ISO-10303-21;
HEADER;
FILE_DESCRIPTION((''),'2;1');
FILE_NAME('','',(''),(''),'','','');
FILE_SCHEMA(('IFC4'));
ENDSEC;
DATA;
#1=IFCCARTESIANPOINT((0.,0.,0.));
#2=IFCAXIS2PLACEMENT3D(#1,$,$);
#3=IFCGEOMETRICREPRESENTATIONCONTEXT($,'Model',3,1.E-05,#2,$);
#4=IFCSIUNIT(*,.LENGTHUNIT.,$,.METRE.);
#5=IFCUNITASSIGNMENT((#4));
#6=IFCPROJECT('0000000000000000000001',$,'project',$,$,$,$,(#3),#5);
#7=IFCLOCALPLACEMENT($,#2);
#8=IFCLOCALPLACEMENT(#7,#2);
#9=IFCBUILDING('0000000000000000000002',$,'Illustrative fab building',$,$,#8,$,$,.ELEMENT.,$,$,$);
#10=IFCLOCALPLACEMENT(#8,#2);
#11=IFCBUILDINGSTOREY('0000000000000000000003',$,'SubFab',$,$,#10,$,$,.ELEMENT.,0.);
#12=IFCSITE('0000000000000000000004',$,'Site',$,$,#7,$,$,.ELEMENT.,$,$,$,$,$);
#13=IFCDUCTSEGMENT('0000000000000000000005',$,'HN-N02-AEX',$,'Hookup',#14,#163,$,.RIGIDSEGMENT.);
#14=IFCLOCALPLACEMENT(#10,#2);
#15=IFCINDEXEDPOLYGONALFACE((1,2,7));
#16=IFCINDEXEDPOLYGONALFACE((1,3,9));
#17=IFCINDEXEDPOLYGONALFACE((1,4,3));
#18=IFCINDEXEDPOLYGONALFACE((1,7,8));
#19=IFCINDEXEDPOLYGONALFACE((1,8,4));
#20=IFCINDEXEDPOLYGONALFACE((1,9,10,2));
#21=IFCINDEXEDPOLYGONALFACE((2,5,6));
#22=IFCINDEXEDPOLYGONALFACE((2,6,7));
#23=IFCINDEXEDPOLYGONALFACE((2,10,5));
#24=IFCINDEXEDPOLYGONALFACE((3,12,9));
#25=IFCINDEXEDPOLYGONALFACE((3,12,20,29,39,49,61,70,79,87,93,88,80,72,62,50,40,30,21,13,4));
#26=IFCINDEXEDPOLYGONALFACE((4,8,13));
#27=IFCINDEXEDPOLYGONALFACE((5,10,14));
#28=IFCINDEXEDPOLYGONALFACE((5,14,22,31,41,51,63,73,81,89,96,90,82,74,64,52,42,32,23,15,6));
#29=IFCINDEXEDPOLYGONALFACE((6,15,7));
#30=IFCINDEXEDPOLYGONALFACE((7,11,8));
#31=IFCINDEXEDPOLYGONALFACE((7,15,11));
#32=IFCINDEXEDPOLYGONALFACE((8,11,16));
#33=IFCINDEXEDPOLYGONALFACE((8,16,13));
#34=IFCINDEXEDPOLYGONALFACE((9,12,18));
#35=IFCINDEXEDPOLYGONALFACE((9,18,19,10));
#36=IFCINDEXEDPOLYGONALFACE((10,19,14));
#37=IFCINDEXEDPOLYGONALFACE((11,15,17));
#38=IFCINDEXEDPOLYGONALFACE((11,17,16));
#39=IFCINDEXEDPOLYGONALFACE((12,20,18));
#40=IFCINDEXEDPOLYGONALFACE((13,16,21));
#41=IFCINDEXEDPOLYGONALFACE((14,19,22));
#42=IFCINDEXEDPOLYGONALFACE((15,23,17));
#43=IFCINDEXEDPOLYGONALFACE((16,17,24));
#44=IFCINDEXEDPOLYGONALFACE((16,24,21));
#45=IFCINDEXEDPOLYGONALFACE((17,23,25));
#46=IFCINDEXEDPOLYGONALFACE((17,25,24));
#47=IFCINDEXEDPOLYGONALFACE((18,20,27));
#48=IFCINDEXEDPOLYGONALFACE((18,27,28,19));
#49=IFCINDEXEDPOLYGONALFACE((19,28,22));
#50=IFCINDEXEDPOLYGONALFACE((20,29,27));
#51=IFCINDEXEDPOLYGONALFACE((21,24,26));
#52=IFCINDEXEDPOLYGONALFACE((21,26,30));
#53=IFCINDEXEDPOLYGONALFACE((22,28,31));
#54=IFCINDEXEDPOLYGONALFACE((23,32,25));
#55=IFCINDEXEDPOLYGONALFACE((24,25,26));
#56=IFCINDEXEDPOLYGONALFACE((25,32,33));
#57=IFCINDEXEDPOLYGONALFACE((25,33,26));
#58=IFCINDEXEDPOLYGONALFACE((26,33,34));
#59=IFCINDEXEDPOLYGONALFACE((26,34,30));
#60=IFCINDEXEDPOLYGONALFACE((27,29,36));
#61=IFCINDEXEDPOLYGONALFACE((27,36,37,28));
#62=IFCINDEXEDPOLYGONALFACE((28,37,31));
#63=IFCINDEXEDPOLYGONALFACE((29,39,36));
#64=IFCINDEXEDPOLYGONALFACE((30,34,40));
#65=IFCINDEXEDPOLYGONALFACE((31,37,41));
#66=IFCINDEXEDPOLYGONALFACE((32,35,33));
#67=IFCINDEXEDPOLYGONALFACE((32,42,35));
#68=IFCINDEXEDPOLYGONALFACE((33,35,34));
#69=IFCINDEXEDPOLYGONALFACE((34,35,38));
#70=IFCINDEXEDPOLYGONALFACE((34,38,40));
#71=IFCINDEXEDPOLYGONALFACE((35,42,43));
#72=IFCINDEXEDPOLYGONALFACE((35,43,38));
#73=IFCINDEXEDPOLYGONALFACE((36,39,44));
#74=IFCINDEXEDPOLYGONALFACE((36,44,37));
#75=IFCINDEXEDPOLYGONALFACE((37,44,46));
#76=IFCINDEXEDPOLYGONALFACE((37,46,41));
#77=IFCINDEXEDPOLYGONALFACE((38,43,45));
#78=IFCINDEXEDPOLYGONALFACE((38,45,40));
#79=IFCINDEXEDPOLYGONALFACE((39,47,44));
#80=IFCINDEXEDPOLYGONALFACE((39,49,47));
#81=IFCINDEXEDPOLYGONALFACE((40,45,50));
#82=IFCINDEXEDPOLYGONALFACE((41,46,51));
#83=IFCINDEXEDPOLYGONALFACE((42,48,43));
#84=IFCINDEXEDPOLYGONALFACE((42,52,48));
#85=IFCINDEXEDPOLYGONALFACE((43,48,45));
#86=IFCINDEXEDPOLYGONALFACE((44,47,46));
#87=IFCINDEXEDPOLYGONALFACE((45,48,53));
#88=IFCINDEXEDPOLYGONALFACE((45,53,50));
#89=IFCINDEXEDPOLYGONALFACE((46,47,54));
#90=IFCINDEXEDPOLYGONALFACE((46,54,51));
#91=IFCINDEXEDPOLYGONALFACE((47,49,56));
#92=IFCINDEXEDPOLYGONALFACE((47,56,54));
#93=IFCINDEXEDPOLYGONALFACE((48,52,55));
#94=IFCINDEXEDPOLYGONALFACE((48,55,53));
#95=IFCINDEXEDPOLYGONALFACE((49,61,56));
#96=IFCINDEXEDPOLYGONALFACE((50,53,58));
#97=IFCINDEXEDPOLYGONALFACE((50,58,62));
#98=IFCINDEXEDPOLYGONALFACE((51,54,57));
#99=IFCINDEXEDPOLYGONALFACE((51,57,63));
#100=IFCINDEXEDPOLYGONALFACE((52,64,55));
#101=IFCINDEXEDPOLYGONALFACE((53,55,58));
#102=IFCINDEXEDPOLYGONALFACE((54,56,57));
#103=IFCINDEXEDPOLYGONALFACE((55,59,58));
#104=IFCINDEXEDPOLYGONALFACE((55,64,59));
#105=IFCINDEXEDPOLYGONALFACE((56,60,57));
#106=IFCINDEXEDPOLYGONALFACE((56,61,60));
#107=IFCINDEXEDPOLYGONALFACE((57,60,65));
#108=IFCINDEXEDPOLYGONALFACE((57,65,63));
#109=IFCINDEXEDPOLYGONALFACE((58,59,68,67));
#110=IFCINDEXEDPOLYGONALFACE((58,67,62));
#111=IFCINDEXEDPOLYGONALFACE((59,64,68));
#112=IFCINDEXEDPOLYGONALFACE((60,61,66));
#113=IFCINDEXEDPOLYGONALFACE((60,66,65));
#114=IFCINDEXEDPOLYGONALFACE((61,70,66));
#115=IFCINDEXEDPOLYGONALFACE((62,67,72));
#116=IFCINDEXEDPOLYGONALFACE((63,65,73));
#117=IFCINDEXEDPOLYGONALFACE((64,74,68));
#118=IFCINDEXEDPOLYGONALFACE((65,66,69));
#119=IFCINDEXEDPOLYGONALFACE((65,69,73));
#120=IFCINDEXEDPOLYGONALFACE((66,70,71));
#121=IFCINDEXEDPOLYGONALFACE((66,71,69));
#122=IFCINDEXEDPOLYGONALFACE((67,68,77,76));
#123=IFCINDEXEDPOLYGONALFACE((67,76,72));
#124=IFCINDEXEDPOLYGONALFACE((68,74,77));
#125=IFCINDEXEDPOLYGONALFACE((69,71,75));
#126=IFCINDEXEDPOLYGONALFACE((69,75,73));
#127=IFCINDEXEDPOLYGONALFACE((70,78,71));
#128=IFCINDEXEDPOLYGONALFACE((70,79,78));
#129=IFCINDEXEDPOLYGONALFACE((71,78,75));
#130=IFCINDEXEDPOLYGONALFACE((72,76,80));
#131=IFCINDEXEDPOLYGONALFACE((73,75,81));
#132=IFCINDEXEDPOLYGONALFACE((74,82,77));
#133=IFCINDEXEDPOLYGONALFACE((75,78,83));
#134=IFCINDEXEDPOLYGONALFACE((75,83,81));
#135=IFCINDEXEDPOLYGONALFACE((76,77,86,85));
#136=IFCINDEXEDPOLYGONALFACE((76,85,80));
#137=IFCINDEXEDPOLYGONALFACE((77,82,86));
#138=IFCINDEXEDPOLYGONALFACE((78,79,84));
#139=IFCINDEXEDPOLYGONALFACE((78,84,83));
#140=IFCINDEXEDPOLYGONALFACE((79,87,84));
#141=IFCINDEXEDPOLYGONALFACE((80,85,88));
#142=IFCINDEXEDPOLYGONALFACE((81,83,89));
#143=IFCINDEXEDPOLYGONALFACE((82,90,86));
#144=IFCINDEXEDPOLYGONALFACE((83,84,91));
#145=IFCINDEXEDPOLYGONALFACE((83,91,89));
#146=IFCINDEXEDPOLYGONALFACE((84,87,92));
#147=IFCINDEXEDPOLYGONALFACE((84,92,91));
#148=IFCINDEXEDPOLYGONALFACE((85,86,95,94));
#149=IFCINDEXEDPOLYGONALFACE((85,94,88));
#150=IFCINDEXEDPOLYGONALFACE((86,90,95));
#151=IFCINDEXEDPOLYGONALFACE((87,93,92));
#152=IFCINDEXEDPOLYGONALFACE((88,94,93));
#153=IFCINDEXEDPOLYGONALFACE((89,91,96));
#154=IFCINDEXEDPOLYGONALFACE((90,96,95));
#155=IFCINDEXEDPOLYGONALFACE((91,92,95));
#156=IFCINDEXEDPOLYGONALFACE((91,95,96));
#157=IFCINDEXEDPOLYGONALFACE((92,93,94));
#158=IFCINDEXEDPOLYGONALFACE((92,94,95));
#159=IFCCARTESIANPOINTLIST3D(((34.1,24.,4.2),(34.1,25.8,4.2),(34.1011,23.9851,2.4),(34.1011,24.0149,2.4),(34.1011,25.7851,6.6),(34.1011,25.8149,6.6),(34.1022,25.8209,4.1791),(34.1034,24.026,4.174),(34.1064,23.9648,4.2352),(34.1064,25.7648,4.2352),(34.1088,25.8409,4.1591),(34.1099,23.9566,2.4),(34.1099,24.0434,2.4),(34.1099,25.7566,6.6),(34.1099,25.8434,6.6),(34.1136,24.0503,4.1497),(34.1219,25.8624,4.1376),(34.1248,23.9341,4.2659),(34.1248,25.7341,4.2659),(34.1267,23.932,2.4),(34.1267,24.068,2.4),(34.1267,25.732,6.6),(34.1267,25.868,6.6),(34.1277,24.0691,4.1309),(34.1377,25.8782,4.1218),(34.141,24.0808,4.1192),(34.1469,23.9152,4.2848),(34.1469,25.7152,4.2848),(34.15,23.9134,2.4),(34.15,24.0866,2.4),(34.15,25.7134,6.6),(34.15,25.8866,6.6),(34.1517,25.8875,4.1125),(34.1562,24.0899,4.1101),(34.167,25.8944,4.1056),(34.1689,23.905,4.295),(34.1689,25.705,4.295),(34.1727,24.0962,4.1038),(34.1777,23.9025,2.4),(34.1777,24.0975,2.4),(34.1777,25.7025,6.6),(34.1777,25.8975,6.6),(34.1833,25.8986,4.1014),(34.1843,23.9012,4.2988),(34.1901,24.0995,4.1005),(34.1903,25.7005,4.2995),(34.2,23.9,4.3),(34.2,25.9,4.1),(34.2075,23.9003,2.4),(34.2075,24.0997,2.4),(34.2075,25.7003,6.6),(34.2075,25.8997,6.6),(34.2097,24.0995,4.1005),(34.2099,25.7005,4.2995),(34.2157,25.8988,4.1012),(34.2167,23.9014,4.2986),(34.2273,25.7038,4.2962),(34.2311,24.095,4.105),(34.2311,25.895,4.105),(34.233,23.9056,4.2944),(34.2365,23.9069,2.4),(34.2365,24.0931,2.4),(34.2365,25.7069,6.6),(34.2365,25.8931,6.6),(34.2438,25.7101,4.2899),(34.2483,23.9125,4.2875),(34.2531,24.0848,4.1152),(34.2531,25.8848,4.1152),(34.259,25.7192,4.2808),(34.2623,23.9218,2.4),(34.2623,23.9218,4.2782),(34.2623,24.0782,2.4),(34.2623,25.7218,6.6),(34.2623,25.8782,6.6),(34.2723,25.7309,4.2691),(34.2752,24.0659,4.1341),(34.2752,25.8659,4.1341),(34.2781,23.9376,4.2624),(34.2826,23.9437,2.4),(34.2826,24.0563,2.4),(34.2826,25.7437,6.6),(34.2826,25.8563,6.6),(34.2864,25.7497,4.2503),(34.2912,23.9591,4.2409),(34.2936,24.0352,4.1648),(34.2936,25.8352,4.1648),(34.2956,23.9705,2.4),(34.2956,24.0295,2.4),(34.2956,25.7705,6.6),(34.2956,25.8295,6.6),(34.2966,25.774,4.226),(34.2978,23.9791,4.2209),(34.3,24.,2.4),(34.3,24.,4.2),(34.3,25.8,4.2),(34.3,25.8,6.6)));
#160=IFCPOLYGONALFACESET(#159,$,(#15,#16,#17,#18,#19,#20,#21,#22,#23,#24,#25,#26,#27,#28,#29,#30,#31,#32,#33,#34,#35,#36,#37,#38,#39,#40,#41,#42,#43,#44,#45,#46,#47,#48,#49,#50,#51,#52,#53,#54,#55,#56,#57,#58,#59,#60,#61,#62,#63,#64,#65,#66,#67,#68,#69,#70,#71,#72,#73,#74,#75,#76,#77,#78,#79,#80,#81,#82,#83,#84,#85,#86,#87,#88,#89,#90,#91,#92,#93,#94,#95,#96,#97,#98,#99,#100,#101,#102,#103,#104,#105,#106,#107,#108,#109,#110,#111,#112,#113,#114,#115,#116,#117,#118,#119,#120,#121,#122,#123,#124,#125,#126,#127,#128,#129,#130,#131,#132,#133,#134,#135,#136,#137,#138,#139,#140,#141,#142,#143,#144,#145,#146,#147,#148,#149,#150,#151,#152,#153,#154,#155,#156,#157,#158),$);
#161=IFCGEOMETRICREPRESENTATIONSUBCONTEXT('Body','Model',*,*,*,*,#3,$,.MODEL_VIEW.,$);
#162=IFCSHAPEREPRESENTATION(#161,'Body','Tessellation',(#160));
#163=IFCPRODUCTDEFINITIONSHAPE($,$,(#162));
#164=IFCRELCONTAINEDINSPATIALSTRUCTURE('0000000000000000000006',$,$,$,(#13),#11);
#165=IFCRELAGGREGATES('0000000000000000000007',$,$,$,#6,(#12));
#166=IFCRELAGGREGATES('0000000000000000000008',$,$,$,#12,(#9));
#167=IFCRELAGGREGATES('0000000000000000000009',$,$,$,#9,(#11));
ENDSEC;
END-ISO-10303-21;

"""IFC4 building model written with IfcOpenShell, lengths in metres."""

from ifc_helpers import new_model, entity, si_unit, origin, place, context, subcontext, project, spatial, element, save


model = new_model("IFC4")

# Units and contexts
model_context = context("Model", 3, precision=1e-05, world=origin())
body_context = subcontext(model_context, "Body", "Model", "MODEL_VIEW")
ifc_project = project(units=[si_unit("LENGTHUNIT", "METRE")], contexts=[model_context])

# Site, building, storey
site_placement = place(None, origin())
site = spatial("IfcSite", under=ifc_project, at=site_placement, Name="Site", CompositionType="ELEMENT")
building_placement = place(site_placement, origin())
building = spatial("IfcBuilding", under=site, at=building_placement, Name="Illustrative fab building", CompositionType="ELEMENT")
storey_placement = place(building_placement, origin())
storey = spatial("IfcBuildingStorey", under=building, at=storey_placement, Name="SubFab", CompositionType="ELEMENT", Elevation=0.0)

# Duct segment
duct_segment_1_placement = place(storey_placement, origin())
element("IfcDuctSegment", 1, at=duct_segment_1_placement, inside=storey, Name="HN-N02-AEX", ObjectType="Hookup", PredefinedType="RIGIDSEGMENT", context=body_context, shape_type="AdvancedSweptSolid", body=[
    entity("IfcSweptDiskSolid", entity("IfcPolyline", [entity("IfcCartesianPoint", [34.2, 24.0, 2.4]), entity("IfcCartesianPoint", [34.2, 24.0, 4.2]), entity("IfcCartesianPoint", [34.2, 25.8, 4.2]), entity("IfcCartesianPoint", [34.2, 25.8, 6.6])]), 0.1),
])

save(model, "model.ifc")
